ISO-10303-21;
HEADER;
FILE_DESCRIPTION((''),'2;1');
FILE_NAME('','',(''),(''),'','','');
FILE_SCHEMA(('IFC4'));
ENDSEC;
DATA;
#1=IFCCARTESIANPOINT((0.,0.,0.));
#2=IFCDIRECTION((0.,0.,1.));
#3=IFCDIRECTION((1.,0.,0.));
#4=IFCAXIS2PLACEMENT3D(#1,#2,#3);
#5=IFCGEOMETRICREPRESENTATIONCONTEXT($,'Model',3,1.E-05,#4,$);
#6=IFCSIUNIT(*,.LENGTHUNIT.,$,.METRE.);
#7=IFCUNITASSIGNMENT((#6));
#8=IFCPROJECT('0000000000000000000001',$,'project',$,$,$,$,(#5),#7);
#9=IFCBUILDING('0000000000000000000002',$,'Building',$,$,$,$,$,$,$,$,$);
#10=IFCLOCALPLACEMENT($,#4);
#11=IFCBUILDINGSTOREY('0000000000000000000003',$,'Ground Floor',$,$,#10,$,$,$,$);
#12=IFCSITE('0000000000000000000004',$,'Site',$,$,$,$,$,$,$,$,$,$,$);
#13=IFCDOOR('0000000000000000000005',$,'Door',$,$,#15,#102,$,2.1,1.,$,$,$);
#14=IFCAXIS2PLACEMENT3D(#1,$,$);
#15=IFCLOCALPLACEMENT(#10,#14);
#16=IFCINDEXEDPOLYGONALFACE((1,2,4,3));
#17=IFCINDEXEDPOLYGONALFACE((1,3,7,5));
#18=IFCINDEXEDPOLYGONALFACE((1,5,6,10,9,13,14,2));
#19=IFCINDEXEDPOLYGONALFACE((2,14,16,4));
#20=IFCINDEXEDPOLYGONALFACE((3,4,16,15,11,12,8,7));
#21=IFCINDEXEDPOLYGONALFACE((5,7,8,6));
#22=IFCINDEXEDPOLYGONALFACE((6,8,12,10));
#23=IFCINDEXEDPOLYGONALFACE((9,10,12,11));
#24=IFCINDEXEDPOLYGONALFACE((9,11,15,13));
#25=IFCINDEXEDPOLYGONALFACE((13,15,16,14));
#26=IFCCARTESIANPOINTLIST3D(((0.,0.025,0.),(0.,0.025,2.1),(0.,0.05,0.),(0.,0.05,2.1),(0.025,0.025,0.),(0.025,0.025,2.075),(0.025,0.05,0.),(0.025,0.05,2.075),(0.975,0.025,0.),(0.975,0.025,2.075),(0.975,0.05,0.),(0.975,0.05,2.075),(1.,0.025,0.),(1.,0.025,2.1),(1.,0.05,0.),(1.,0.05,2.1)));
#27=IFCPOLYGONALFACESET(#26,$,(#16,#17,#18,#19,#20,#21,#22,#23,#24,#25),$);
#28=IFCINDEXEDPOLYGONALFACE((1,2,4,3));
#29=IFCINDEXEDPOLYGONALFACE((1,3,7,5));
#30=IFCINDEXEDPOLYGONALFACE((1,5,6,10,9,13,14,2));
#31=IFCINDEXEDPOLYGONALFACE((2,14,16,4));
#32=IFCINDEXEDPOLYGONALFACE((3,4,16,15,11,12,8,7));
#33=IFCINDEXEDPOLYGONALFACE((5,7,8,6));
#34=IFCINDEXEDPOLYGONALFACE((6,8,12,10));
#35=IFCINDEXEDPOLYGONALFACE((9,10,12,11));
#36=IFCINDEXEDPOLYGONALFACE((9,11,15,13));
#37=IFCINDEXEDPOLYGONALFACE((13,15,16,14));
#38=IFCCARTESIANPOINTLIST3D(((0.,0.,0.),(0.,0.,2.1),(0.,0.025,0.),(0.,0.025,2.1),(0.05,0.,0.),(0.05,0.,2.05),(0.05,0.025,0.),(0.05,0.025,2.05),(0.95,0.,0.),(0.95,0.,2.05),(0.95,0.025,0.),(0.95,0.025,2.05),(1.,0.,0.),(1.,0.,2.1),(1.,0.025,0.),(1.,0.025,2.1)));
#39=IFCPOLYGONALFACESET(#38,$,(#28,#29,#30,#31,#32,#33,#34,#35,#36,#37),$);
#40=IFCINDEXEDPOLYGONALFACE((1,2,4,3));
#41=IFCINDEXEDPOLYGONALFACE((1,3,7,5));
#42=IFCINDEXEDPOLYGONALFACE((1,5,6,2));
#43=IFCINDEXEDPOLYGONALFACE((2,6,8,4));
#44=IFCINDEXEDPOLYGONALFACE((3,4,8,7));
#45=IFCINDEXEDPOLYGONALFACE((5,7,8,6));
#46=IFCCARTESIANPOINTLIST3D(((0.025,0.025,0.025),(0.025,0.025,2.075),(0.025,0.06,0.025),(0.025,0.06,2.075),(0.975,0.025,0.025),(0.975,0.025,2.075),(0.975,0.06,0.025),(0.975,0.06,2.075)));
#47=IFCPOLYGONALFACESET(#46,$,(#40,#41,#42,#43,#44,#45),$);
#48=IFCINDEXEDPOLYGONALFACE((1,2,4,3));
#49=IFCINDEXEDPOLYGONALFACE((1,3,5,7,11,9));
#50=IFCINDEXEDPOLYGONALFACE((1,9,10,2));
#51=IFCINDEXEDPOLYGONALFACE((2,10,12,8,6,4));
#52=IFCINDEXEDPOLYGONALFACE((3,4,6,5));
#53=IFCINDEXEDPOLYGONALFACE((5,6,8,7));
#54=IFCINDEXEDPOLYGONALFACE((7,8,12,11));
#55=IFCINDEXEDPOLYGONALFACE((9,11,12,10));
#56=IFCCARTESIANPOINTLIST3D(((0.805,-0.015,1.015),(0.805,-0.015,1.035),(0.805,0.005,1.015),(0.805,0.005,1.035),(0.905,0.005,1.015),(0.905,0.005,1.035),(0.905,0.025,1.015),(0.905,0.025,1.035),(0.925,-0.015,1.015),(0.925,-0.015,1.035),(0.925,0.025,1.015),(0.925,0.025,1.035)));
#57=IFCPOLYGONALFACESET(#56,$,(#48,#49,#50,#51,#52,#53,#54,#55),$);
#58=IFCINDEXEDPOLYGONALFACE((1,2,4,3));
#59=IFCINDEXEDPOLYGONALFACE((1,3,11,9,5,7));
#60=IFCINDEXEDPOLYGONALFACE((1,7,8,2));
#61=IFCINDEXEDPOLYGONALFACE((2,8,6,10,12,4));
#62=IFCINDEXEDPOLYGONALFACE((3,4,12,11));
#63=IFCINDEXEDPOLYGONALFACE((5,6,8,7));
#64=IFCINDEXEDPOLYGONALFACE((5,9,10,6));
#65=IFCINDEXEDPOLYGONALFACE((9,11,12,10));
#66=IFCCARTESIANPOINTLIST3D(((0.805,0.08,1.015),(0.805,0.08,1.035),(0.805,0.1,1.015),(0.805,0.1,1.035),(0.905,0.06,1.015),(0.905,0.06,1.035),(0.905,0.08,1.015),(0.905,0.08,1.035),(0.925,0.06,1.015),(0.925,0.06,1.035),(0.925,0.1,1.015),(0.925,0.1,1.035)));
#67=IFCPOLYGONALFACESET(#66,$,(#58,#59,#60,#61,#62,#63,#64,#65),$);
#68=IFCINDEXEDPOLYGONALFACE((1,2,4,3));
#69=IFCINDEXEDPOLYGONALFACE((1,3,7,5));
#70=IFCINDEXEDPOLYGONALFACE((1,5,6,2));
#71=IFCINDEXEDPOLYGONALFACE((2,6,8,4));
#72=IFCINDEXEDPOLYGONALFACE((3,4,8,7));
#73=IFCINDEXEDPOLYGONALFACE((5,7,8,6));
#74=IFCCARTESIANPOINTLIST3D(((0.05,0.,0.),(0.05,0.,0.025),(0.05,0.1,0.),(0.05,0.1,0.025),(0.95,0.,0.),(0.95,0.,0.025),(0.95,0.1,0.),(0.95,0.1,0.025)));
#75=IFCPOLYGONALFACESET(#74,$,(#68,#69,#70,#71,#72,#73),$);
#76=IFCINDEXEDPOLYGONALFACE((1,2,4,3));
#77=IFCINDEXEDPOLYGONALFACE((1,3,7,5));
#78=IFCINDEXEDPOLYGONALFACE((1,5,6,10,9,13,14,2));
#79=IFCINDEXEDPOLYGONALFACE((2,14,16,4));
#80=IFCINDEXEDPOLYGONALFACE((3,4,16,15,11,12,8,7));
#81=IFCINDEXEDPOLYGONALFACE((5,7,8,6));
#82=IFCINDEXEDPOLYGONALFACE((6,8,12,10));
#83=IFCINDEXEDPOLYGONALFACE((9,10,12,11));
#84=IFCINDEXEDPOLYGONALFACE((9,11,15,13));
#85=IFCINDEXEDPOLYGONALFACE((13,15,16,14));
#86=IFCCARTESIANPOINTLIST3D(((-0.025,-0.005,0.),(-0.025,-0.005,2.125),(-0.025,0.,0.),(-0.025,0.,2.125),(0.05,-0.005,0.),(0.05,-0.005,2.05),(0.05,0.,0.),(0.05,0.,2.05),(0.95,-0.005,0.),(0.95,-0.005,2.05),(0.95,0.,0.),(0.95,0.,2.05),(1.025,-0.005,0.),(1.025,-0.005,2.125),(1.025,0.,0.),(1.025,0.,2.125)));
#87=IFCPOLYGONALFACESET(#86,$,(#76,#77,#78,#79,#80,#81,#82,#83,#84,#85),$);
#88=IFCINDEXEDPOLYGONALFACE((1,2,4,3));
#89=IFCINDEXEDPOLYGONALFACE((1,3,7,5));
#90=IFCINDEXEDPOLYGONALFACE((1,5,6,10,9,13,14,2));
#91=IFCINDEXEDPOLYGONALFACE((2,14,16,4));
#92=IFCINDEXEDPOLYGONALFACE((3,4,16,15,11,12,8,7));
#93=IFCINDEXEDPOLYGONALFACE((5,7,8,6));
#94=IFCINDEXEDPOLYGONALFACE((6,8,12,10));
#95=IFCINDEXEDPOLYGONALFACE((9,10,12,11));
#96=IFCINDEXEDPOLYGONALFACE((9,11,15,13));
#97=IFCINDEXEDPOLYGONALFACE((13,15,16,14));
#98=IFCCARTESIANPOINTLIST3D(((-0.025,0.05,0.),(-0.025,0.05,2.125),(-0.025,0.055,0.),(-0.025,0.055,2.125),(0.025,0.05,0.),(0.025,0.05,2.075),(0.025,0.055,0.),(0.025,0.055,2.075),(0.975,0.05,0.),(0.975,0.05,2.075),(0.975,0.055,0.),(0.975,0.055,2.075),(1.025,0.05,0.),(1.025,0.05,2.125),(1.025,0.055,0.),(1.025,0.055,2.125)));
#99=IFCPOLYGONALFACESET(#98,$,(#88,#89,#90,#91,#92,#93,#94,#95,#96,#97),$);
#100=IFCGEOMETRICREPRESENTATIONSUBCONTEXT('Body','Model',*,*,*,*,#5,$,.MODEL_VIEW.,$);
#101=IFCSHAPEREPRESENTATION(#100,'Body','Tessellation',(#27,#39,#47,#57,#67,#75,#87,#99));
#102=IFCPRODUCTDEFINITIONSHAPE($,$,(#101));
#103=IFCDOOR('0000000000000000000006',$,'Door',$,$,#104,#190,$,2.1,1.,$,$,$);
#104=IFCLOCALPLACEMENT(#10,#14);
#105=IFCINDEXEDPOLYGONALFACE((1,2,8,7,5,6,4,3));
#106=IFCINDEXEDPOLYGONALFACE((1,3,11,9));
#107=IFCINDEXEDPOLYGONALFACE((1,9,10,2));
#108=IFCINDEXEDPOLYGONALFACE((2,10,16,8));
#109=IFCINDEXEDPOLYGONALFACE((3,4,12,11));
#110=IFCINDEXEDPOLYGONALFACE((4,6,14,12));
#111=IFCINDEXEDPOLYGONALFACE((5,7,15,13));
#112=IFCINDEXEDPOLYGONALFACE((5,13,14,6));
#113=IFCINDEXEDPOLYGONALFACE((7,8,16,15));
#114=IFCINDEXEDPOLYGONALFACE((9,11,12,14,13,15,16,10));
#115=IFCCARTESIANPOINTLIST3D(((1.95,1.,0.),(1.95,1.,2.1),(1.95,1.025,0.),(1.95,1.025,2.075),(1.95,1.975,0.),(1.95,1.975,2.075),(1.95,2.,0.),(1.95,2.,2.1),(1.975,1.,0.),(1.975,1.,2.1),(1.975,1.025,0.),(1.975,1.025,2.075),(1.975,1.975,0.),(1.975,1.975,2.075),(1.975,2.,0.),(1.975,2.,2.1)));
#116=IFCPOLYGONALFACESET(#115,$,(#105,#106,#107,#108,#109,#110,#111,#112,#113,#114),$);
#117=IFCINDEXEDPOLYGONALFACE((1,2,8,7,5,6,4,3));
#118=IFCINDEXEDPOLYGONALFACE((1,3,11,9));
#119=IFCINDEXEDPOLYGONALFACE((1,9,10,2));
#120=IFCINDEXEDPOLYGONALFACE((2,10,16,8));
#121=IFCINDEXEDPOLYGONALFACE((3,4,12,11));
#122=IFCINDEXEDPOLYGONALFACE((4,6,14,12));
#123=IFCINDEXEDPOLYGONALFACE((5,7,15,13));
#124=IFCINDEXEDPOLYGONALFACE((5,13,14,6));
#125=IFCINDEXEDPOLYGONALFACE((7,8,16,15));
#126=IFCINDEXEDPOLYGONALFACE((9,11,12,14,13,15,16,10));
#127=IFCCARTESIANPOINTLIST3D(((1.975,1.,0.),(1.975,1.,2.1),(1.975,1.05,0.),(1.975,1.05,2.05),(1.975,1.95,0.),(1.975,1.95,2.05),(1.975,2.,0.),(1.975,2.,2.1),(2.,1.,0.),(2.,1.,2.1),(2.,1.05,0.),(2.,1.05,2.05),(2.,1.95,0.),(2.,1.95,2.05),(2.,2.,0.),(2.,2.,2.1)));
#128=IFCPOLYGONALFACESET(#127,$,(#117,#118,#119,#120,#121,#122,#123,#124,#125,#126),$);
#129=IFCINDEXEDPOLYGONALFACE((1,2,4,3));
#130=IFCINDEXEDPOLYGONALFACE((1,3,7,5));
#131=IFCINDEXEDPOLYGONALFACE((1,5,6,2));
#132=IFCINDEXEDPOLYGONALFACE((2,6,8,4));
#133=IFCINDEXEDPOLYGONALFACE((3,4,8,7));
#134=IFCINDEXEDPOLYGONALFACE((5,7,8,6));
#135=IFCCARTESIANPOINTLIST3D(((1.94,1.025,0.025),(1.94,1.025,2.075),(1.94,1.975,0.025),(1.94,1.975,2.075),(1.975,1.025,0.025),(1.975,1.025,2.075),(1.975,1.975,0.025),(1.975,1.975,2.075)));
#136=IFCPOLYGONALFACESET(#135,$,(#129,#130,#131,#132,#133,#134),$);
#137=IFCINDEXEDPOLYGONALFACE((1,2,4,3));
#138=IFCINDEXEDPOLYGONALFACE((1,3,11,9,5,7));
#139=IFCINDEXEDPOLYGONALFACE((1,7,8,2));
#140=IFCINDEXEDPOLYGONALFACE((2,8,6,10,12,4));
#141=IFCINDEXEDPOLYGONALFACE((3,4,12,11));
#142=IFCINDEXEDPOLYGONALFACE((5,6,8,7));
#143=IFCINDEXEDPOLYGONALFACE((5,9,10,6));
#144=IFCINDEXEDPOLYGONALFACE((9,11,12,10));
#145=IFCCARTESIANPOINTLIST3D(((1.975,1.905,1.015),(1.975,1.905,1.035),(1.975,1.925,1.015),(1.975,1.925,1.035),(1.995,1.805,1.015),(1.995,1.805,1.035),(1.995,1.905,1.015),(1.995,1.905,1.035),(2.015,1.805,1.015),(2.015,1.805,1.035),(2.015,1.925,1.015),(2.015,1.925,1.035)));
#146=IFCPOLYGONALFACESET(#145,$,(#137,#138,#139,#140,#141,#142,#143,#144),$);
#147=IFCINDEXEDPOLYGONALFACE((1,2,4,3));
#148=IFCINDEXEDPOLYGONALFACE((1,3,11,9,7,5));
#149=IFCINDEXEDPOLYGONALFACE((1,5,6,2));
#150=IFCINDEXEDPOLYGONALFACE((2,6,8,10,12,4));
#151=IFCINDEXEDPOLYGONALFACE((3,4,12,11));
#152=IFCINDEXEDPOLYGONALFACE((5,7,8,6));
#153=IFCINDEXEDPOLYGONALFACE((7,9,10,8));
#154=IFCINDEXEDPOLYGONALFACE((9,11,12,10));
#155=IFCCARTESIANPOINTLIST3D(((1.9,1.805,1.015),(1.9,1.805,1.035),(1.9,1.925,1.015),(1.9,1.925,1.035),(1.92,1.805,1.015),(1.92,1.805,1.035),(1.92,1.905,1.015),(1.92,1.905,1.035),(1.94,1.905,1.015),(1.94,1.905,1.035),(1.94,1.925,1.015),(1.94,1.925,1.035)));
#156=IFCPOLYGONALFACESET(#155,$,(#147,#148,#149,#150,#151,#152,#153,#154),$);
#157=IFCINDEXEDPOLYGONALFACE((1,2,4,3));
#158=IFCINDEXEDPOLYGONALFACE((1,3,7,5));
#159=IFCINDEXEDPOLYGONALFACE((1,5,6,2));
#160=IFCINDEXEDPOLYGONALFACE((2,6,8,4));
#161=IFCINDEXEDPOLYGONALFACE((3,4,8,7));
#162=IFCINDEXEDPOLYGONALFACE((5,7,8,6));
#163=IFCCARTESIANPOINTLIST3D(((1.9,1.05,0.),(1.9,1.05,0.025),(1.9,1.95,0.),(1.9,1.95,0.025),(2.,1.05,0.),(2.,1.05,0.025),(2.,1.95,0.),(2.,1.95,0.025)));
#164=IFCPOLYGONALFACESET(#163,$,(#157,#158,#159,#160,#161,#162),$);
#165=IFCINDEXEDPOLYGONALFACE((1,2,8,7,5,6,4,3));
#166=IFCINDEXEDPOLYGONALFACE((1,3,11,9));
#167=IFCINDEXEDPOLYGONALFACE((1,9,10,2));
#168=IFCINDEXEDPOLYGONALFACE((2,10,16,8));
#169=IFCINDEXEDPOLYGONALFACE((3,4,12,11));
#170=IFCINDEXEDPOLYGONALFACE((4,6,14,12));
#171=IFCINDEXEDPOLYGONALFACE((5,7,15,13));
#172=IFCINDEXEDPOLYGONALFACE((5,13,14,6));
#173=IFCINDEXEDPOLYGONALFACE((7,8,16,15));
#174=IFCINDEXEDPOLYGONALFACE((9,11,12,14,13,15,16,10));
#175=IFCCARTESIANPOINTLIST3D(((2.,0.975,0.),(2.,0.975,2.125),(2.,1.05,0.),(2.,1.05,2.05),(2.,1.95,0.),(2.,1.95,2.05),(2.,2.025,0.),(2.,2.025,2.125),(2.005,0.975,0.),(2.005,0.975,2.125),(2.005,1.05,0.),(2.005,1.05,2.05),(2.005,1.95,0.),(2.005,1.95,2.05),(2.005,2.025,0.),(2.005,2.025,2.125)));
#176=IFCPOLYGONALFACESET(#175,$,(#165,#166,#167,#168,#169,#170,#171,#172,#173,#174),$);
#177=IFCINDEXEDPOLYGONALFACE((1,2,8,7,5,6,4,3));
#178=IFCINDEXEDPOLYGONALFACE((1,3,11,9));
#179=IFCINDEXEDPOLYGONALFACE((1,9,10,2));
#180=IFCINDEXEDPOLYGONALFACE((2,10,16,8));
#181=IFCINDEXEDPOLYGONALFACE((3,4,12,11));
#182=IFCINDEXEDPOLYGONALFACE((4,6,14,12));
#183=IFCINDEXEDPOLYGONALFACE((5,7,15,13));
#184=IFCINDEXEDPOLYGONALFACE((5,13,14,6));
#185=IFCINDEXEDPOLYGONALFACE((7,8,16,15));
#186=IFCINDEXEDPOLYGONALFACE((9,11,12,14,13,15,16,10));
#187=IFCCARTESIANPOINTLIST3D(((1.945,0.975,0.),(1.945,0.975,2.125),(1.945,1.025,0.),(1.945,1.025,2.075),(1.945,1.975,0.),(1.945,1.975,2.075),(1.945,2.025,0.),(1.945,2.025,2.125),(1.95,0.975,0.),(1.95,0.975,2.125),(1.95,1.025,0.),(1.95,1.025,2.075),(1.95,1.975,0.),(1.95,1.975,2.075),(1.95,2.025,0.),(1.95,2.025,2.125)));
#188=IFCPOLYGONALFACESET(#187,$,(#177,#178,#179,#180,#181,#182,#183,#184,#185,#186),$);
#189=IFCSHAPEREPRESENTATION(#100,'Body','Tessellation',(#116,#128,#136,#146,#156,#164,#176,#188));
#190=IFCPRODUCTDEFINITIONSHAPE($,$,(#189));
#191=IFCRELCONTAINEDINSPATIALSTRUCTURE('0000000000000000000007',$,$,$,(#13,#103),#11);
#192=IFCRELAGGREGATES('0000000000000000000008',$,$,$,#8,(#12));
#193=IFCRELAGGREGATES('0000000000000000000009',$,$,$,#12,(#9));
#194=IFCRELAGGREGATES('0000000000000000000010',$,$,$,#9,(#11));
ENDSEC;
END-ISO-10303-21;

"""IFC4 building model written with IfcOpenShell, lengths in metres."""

from ifc_helpers import new_model, si_unit, frame, origin_with_axes, place, context, subcontext, project, spatial, line, indexed_curve, outline, extrude, element, save


model = new_model("IFC4")

# Units and contexts
model_context = context("Model", 3, precision=1e-05, world=origin_with_axes())
body_context = subcontext(model_context, "Body", "Model", "MODEL_VIEW")
ifc_project = project(units=[si_unit("LENGTHUNIT", "METRE")], contexts=[model_context])

# Site, building, storey
site = spatial("IfcSite", under=ifc_project, Name="Site")
building = spatial("IfcBuilding", under=site, Name="Building")
storey_placement = place(None, origin_with_axes())
storey = spatial("IfcBuildingStorey", under=building, at=storey_placement, Name="Ground Floor")

# Doors
door_1_placement = place(storey_placement, origin_with_axes())
element("IfcDoor", 1, at=door_1_placement, inside=storey, Name="Door", OverallHeight=2.1, OverallWidth=1.0, context=body_context, shape_type="SweptSolid", body=[
    extrude(outline(indexed_curve([(0.0, 0.0), (0.0, 2.1), (1.0, 2.1), (1.0, 0.0), (0.975, 0.0), (0.975, 2.075), (0.025, 2.075), (0.025, 0.0)], segments=[line(1, 2, 3, 4, 5, 6, 7, 8, 1)])), frame((0.0, 0.025, 0.0), z_axis=(0.0, -1.0, 0.0), x_axis=(1.0, 0.0, 0.0)), (0.0, 0.0, -1.0), 0.025),
    extrude(outline(indexed_curve([(0.0, 0.0), (0.0, 2.1), (1.0, 2.1), (1.0, 0.0), (0.95, 0.0), (0.95, 2.05), (0.05, 2.05), (0.05, 0.0)], segments=[line(1, 2, 3, 4, 5, 6, 7, 8, 1)])), frame((0.0, 0.0, 0.0), z_axis=(0.0, -1.0, 0.0), x_axis=(1.0, 0.0, 0.0)), (0.0, 0.0, -1.0), 0.025),
    extrude(outline(indexed_curve([(0.0, 0.0), (0.95, 0.0), (0.95, 0.035), (0.0, 0.035)], segments=[line(1, 2, 3, 4, 1)])), frame((0.025, 0.025, 0.025), z_axis=(0.0, 0.0, 1.0), x_axis=(1.0, 0.0, 0.0)), (0.0, 0.0, 1.0), 2.05),
    extrude(outline(indexed_curve([(0.0, 0.0), (0.0, -0.04), (-0.12, -0.04), (-0.12, -0.02), (-0.02, -0.02), (-0.02, 0.0)], segments=[line(1, 2, 3, 4, 5, 6, 1)])), frame((0.925, 0.025, 1.015), z_axis=(0.0, 0.0, 1.0), x_axis=(1.0, 0.0, 0.0)), (0.0, 0.0, 1.0), 0.02),
    extrude(outline(indexed_curve([(0.0, 0.0), (0.0, 0.04), (-0.12, 0.04), (-0.12, 0.02), (-0.02, 0.02), (-0.02, 0.0)], segments=[line(1, 2, 3, 4, 5, 6, 1)])), frame((0.925, 0.06, 1.015), z_axis=(0.0, 0.0, 1.0), x_axis=(1.0, 0.0, 0.0)), (0.0, 0.0, 1.0), 0.02),
    extrude(outline(indexed_curve([(0.0, 0.0), (0.9, 0.0), (0.9, 0.1), (0.0, 0.1)], segments=[line(1, 2, 3, 4, 1)])), frame((0.05, 0.0, 0.0), z_axis=(0.0, 0.0, 1.0), x_axis=(1.0, 0.0, 0.0)), (0.0, 0.0, 1.0), 0.025),
    extrude(outline(indexed_curve([(0.0, 0.0), (0.0, 2.125), (1.05, 2.125), (1.05, 0.0), (0.975, 0.0), (0.975, 2.05), (0.075, 2.05), (0.075, 0.0)], segments=[line(1, 2, 3, 4, 5, 6, 7, 8, 1)])), frame((-0.025, -0.005, 0.0), z_axis=(0.0, -1.0, 0.0), x_axis=(1.0, 0.0, 0.0)), (0.0, 0.0, -1.0), 0.005),
    extrude(outline(indexed_curve([(0.0, 0.0), (0.0, 2.125), (1.05, 2.125), (1.05, 0.0), (1.0, 0.0), (1.0, 2.075), (0.05, 2.075), (0.05, 0.0)], segments=[line(1, 2, 3, 4, 5, 6, 7, 8, 1)])), frame((-0.025, 0.05, 0.0), z_axis=(0.0, -1.0, 0.0), x_axis=(1.0, 0.0, 0.0)), (0.0, 0.0, -1.0), 0.005),
])
door_2_placement = place(storey_placement, frame((2.0, 1.0, 0.0), z_axis=(0.0, 0.0, 1.0), x_axis=(0.0, 1.0, 0.0)))
element("IfcDoor", 2, at=door_2_placement, inside=storey, Name="Door", OverallHeight=2.1, OverallWidth=1.0, context=body_context, shape_type="SweptSolid", body=[
    extrude(outline(indexed_curve([(0.0, 0.0), (0.0, 2.1), (1.0, 2.1), (1.0, 0.0), (0.975, 0.0), (0.975, 2.075), (0.025, 2.075), (0.025, 0.0)], segments=[line(1, 2, 3, 4, 5, 6, 7, 8, 1)])), frame((0.0, 0.025, 0.0), z_axis=(0.0, -1.0, 0.0), x_axis=(1.0, 0.0, 0.0)), (0.0, 0.0, -1.0), 0.025),
    extrude(outline(indexed_curve([(0.0, 0.0), (0.0, 2.1), (1.0, 2.1), (1.0, 0.0), (0.95, 0.0), (0.95, 2.05), (0.05, 2.05), (0.05, 0.0)], segments=[line(1, 2, 3, 4, 5, 6, 7, 8, 1)])), frame((0.0, 0.0, 0.0), z_axis=(0.0, -1.0, 0.0), x_axis=(1.0, 0.0, 0.0)), (0.0, 0.0, -1.0), 0.025),
    extrude(outline(indexed_curve([(0.0, 0.0), (0.95, 0.0), (0.95, 0.035), (0.0, 0.035)], segments=[line(1, 2, 3, 4, 1)])), frame((0.025, 0.025, 0.025), z_axis=(0.0, 0.0, 1.0), x_axis=(1.0, 0.0, 0.0)), (0.0, 0.0, 1.0), 2.05),
    extrude(outline(indexed_curve([(0.0, 0.0), (0.0, -0.04), (-0.12, -0.04), (-0.12, -0.02), (-0.02, -0.02), (-0.02, 0.0)], segments=[line(1, 2, 3, 4, 5, 6, 1)])), frame((0.925, 0.025, 1.015), z_axis=(0.0, 0.0, 1.0), x_axis=(1.0, 0.0, 0.0)), (0.0, 0.0, 1.0), 0.02),
    extrude(outline(indexed_curve([(0.0, 0.0), (0.0, 0.04), (-0.12, 0.04), (-0.12, 0.02), (-0.02, 0.02), (-0.02, 0.0)], segments=[line(1, 2, 3, 4, 5, 6, 1)])), frame((0.925, 0.06, 1.015), z_axis=(0.0, 0.0, 1.0), x_axis=(1.0, 0.0, 0.0)), (0.0, 0.0, 1.0), 0.02),
    extrude(outline(indexed_curve([(0.0, 0.0), (0.9, 0.0), (0.9, 0.1), (0.0, 0.1)], segments=[line(1, 2, 3, 4, 1)])), frame((0.05, 0.0, 0.0), z_axis=(0.0, 0.0, 1.0), x_axis=(1.0, 0.0, 0.0)), (0.0, 0.0, 1.0), 0.025),
    extrude(outline(indexed_curve([(0.0, 0.0), (0.0, 2.125), (1.05, 2.125), (1.05, 0.0), (0.975, 0.0), (0.975, 2.05), (0.075, 2.05), (0.075, 0.0)], segments=[line(1, 2, 3, 4, 5, 6, 7, 8, 1)])), frame((-0.025, -0.005, 0.0), z_axis=(0.0, -1.0, 0.0), x_axis=(1.0, 0.0, 0.0)), (0.0, 0.0, -1.0), 0.005),
    extrude(outline(indexed_curve([(0.0, 0.0), (0.0, 2.125), (1.05, 2.125), (1.05, 0.0), (1.0, 0.0), (1.0, 2.075), (0.05, 2.075), (0.05, 0.0)], segments=[line(1, 2, 3, 4, 5, 6, 7, 8, 1)])), frame((-0.025, 0.05, 0.0), z_axis=(0.0, -1.0, 0.0), x_axis=(1.0, 0.0, 0.0)), (0.0, 0.0, -1.0), 0.005),
])

save(model, "model.ifc")
